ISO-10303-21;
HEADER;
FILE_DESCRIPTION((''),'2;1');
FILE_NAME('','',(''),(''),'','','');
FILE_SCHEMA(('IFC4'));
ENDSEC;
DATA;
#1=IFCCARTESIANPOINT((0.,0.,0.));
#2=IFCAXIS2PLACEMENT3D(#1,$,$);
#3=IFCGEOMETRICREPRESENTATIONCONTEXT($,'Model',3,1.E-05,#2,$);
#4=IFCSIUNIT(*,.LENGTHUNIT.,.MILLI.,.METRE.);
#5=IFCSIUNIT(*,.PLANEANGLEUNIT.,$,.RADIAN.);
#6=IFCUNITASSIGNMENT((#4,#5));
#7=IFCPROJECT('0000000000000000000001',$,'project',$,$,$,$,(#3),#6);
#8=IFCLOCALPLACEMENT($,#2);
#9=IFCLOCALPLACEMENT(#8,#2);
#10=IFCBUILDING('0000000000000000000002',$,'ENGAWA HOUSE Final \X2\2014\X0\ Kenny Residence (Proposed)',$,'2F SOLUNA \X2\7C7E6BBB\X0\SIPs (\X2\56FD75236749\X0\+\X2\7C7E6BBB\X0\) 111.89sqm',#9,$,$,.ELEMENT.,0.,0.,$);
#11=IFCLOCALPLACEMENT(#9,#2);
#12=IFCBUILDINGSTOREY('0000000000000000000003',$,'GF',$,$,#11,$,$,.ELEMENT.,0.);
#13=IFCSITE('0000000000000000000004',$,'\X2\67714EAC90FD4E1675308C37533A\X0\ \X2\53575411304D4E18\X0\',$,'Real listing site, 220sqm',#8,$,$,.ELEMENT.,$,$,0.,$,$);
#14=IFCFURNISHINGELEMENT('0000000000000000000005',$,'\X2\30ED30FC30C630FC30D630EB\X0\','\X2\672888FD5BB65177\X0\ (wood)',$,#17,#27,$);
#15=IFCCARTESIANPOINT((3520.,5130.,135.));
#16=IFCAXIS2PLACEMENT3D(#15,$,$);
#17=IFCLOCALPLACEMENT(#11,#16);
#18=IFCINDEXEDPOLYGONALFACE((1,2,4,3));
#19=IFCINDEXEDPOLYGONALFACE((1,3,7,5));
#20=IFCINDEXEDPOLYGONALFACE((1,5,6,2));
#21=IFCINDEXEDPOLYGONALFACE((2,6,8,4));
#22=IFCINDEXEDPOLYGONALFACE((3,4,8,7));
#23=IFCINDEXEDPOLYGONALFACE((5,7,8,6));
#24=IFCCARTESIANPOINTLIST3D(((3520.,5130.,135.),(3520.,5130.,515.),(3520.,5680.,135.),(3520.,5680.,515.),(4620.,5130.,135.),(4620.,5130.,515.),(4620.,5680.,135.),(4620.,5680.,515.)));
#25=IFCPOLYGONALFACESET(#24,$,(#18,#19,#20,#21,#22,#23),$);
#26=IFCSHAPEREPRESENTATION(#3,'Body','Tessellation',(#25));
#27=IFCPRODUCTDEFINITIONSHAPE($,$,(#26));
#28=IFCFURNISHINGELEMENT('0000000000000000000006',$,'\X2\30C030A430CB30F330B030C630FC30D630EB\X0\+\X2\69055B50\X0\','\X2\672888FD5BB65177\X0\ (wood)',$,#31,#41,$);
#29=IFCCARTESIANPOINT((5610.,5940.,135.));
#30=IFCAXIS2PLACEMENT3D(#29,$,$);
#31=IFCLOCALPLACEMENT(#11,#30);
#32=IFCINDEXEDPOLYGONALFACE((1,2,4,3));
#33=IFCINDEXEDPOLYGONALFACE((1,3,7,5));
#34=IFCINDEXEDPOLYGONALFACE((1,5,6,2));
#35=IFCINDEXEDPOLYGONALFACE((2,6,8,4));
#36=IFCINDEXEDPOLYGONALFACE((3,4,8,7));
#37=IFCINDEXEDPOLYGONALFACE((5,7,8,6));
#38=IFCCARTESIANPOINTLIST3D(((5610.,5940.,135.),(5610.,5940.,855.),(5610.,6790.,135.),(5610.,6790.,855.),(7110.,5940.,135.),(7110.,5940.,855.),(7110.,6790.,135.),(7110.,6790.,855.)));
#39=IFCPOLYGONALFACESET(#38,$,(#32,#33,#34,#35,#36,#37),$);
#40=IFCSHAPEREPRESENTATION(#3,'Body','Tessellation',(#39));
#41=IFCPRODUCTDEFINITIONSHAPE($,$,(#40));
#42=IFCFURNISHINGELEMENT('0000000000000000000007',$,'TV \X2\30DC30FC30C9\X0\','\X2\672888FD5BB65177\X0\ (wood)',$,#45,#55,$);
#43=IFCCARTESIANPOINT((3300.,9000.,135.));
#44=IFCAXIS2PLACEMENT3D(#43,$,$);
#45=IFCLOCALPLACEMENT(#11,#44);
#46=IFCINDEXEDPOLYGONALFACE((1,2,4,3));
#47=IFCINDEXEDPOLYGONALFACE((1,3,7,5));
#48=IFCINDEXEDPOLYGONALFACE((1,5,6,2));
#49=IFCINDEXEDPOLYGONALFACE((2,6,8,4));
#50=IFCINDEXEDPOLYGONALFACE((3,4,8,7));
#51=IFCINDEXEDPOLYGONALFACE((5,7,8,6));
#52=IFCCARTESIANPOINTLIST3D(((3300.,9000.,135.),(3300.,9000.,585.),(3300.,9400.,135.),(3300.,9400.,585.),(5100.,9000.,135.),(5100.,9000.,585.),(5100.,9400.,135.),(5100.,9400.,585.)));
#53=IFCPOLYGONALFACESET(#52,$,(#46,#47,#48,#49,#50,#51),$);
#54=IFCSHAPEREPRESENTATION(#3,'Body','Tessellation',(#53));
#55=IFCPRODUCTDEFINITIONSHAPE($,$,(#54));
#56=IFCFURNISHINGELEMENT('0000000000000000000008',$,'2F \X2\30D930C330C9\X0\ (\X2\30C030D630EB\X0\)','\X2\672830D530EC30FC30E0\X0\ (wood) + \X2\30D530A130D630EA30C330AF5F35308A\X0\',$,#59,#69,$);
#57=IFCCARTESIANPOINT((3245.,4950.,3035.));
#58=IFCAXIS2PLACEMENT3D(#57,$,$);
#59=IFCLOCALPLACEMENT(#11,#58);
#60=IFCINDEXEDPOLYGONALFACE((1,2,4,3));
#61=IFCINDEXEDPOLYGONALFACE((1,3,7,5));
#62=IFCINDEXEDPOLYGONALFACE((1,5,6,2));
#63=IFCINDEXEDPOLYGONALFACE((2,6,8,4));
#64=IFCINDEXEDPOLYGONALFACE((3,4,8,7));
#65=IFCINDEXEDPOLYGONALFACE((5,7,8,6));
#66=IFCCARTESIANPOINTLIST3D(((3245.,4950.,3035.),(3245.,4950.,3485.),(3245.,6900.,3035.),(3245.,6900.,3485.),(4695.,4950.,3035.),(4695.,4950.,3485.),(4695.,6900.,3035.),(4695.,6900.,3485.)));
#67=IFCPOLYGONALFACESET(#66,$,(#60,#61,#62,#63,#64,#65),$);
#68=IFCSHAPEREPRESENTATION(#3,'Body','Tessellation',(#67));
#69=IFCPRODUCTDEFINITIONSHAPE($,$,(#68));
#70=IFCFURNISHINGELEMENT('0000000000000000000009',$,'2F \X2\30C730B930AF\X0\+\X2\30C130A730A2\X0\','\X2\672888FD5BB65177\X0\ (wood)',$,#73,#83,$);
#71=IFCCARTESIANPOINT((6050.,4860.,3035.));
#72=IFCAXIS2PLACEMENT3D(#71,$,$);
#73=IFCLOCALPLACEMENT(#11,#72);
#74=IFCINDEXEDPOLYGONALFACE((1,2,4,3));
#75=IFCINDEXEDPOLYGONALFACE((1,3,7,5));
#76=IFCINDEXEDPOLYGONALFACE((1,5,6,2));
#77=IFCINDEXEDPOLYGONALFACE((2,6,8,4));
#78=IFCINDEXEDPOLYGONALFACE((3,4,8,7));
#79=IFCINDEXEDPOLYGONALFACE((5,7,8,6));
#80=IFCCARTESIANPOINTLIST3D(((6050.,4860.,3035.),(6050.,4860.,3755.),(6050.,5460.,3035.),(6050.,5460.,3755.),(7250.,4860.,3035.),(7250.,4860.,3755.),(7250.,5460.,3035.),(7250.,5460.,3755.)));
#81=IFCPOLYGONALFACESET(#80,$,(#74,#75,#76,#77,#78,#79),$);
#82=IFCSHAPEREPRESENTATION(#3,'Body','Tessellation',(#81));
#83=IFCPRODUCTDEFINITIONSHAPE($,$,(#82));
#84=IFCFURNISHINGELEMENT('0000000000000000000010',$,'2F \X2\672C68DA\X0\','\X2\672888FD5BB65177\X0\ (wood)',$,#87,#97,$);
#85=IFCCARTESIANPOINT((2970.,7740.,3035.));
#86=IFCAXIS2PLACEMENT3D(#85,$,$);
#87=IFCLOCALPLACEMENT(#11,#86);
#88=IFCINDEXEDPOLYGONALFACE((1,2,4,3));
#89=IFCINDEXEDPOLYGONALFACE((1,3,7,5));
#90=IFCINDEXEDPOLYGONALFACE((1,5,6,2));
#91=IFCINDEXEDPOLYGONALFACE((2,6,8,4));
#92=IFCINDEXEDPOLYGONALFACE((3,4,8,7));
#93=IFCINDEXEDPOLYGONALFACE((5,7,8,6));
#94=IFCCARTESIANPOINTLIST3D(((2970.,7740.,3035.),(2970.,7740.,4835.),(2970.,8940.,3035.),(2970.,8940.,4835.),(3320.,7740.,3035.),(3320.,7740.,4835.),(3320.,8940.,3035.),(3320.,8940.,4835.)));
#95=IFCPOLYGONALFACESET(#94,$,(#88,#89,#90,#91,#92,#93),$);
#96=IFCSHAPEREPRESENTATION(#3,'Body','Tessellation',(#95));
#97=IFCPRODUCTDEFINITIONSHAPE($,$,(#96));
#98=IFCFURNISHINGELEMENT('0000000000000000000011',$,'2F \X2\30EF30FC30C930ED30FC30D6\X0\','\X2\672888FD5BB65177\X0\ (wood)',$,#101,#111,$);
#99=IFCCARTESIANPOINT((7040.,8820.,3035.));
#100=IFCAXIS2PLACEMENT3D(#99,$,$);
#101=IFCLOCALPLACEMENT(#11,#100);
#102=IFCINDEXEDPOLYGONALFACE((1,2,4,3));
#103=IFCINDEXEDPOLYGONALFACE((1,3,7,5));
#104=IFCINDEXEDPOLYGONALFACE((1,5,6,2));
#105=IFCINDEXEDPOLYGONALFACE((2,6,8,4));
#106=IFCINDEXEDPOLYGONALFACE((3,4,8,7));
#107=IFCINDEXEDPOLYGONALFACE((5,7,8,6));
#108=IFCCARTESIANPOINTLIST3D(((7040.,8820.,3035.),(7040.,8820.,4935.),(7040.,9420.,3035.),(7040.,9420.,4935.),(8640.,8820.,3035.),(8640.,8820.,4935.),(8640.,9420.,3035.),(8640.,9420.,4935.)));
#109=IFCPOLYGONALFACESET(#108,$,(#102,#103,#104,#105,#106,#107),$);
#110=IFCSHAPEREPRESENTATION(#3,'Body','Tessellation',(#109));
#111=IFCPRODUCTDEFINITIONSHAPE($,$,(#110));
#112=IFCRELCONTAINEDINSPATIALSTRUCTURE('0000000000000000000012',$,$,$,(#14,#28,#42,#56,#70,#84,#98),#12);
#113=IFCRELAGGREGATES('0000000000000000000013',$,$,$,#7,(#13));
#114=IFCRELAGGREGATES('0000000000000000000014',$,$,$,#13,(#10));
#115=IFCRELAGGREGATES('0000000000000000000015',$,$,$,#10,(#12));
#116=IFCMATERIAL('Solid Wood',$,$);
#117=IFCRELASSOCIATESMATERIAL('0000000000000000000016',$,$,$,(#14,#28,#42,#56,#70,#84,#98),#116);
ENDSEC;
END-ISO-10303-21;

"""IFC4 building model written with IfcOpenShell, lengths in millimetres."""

from ifc_helpers import new_model, si_unit, frame, frame_2d, origin, place, context, project, spatial, rectangle, extrude, material, element, save


model = new_model("IFC4")

# Units and contexts
model_context = context("Model", 3, precision=1e-05, world=origin())
ifc_project = project(units=[si_unit("LENGTHUNIT", "METRE", prefix="MILLI"), si_unit("PLANEANGLEUNIT", "RADIAN")], contexts=[model_context])

# Site, building, storey
site_placement = place(None, origin())
site = spatial("IfcSite", under=ifc_project, at=site_placement, Name="東京都世田谷区 南向き丘", ObjectType="Real listing site, 220sqm", CompositionType="ELEMENT", RefElevation=0.0)
building_placement = place(site_placement, origin())
building = spatial("IfcBuilding", under=site, at=building_placement, Name="ENGAWA HOUSE Final — Kenny Residence (Proposed)", ObjectType="2F SOLUNA 籾殻SIPs (国産杉+籾殻) 111.89sqm", CompositionType="ELEMENT", ElevationOfRefHeight=0.0, ElevationOfTerrain=0.0)
storey_placement = place(building_placement, origin())
storey = spatial("IfcBuildingStorey", under=building, at=storey_placement, Name="GF", CompositionType="ELEMENT", Elevation=0.0)

# Shared definitions
ifc_material_1 = material(Name="Solid Wood")

# Furnishing elements
furnishing_1_placement = place(storey_placement, frame((3520.0, 5130.0, 135.0)))
element("IfcFurnishingElement", 1, at=furnishing_1_placement, inside=storey, material=ifc_material_1, Name="ローテーブル", Description="木製家具 (wood)", context=model_context, shape_type="SweptSolid", body=[
    extrude(rectangle(XDim=1100.0, YDim=550.0, at=frame_2d((550.0, 275.0))), frame((3520.0, 5130.0, 135.0)), (0.0, 0.0, 1.0), 380.0),
])
furnishing_2_placement = place(storey_placement, frame((5610.0, 5940.0, 135.0)))
element("IfcFurnishingElement", 2, at=furnishing_2_placement, inside=storey, material=ifc_material_1, Name="ダイニングテーブル+椅子", Description="木製家具 (wood)", context=model_context, shape_type="SweptSolid", body=[
    extrude(rectangle(XDim=1500.0, YDim=850.0, at=frame_2d((750.0, 425.0))), frame((5610.0, 5940.0, 135.0)), (0.0, 0.0, 1.0), 720.0),
])
furnishing_3_placement = place(storey_placement, frame((3300.0, 9000.0, 135.0)))
element("IfcFurnishingElement", 3, at=furnishing_3_placement, inside=storey, material=ifc_material_1, Name="TV ボード", Description="木製家具 (wood)", context=model_context, shape_type="SweptSolid", body=[
    extrude(rectangle(XDim=1800.0, YDim=400.0, at=frame_2d((900.0, 200.0))), frame((3300.0, 9000.0, 135.0)), (0.0, 0.0, 1.0), 450.0),
])
furnishing_4_placement = place(storey_placement, frame((3245.0, 4950.0, 3035.0)))
element("IfcFurnishingElement", 4, at=furnishing_4_placement, inside=storey, material=ifc_material_1, Name="2F ベッド (ダブル)", Description="木フレーム (wood) + ファブリック張り", context=model_context, shape_type="SweptSolid", body=[
    extrude(rectangle(XDim=1450.0, YDim=1950.0, at=frame_2d((725.0, 975.0))), frame((3245.0, 4950.0, 3035.0)), (0.0, 0.0, 1.0), 450.0),
])
furnishing_5_placement = place(storey_placement, frame((6050.0, 4860.0, 3035.0)))
element("IfcFurnishingElement", 5, at=furnishing_5_placement, inside=storey, material=ifc_material_1, Name="2F デスク+チェア", Description="木製家具 (wood)", context=model_context, shape_type="SweptSolid", body=[
    extrude(rectangle(XDim=1200.0, YDim=600.0, at=frame_2d((600.0, 300.0))), frame((6050.0, 4860.0, 3035.0)), (0.0, 0.0, 1.0), 720.0),
])
furnishing_6_placement = place(storey_placement, frame((2970.0, 7740.0, 3035.0)))
element("IfcFurnishingElement", 6, at=furnishing_6_placement, inside=storey, material=ifc_material_1, Name="2F 本棚", Description="木製家具 (wood)", context=model_context, shape_type="SweptSolid", body=[
    extrude(rectangle(XDim=350.0, YDim=1200.0, at=frame_2d((175.0, 600.0))), frame((2970.0, 7740.0, 3035.0)), (0.0, 0.0, 1.0), 1800.0),
])
furnishing_7_placement = place(storey_placement, frame((7040.0, 8820.0, 3035.0)))
element("IfcFurnishingElement", 7, at=furnishing_7_placement, inside=storey, material=ifc_material_1, Name="2F ワードローブ", Description="木製家具 (wood)", context=model_context, shape_type="SweptSolid", body=[
    extrude(rectangle(XDim=1600.0, YDim=600.0, at=frame_2d((800.0, 300.0))), frame((7040.0, 8820.0, 3035.0)), (0.0, 0.0, 1.0), 1900.0),
])

save(model, "model.ifc")
